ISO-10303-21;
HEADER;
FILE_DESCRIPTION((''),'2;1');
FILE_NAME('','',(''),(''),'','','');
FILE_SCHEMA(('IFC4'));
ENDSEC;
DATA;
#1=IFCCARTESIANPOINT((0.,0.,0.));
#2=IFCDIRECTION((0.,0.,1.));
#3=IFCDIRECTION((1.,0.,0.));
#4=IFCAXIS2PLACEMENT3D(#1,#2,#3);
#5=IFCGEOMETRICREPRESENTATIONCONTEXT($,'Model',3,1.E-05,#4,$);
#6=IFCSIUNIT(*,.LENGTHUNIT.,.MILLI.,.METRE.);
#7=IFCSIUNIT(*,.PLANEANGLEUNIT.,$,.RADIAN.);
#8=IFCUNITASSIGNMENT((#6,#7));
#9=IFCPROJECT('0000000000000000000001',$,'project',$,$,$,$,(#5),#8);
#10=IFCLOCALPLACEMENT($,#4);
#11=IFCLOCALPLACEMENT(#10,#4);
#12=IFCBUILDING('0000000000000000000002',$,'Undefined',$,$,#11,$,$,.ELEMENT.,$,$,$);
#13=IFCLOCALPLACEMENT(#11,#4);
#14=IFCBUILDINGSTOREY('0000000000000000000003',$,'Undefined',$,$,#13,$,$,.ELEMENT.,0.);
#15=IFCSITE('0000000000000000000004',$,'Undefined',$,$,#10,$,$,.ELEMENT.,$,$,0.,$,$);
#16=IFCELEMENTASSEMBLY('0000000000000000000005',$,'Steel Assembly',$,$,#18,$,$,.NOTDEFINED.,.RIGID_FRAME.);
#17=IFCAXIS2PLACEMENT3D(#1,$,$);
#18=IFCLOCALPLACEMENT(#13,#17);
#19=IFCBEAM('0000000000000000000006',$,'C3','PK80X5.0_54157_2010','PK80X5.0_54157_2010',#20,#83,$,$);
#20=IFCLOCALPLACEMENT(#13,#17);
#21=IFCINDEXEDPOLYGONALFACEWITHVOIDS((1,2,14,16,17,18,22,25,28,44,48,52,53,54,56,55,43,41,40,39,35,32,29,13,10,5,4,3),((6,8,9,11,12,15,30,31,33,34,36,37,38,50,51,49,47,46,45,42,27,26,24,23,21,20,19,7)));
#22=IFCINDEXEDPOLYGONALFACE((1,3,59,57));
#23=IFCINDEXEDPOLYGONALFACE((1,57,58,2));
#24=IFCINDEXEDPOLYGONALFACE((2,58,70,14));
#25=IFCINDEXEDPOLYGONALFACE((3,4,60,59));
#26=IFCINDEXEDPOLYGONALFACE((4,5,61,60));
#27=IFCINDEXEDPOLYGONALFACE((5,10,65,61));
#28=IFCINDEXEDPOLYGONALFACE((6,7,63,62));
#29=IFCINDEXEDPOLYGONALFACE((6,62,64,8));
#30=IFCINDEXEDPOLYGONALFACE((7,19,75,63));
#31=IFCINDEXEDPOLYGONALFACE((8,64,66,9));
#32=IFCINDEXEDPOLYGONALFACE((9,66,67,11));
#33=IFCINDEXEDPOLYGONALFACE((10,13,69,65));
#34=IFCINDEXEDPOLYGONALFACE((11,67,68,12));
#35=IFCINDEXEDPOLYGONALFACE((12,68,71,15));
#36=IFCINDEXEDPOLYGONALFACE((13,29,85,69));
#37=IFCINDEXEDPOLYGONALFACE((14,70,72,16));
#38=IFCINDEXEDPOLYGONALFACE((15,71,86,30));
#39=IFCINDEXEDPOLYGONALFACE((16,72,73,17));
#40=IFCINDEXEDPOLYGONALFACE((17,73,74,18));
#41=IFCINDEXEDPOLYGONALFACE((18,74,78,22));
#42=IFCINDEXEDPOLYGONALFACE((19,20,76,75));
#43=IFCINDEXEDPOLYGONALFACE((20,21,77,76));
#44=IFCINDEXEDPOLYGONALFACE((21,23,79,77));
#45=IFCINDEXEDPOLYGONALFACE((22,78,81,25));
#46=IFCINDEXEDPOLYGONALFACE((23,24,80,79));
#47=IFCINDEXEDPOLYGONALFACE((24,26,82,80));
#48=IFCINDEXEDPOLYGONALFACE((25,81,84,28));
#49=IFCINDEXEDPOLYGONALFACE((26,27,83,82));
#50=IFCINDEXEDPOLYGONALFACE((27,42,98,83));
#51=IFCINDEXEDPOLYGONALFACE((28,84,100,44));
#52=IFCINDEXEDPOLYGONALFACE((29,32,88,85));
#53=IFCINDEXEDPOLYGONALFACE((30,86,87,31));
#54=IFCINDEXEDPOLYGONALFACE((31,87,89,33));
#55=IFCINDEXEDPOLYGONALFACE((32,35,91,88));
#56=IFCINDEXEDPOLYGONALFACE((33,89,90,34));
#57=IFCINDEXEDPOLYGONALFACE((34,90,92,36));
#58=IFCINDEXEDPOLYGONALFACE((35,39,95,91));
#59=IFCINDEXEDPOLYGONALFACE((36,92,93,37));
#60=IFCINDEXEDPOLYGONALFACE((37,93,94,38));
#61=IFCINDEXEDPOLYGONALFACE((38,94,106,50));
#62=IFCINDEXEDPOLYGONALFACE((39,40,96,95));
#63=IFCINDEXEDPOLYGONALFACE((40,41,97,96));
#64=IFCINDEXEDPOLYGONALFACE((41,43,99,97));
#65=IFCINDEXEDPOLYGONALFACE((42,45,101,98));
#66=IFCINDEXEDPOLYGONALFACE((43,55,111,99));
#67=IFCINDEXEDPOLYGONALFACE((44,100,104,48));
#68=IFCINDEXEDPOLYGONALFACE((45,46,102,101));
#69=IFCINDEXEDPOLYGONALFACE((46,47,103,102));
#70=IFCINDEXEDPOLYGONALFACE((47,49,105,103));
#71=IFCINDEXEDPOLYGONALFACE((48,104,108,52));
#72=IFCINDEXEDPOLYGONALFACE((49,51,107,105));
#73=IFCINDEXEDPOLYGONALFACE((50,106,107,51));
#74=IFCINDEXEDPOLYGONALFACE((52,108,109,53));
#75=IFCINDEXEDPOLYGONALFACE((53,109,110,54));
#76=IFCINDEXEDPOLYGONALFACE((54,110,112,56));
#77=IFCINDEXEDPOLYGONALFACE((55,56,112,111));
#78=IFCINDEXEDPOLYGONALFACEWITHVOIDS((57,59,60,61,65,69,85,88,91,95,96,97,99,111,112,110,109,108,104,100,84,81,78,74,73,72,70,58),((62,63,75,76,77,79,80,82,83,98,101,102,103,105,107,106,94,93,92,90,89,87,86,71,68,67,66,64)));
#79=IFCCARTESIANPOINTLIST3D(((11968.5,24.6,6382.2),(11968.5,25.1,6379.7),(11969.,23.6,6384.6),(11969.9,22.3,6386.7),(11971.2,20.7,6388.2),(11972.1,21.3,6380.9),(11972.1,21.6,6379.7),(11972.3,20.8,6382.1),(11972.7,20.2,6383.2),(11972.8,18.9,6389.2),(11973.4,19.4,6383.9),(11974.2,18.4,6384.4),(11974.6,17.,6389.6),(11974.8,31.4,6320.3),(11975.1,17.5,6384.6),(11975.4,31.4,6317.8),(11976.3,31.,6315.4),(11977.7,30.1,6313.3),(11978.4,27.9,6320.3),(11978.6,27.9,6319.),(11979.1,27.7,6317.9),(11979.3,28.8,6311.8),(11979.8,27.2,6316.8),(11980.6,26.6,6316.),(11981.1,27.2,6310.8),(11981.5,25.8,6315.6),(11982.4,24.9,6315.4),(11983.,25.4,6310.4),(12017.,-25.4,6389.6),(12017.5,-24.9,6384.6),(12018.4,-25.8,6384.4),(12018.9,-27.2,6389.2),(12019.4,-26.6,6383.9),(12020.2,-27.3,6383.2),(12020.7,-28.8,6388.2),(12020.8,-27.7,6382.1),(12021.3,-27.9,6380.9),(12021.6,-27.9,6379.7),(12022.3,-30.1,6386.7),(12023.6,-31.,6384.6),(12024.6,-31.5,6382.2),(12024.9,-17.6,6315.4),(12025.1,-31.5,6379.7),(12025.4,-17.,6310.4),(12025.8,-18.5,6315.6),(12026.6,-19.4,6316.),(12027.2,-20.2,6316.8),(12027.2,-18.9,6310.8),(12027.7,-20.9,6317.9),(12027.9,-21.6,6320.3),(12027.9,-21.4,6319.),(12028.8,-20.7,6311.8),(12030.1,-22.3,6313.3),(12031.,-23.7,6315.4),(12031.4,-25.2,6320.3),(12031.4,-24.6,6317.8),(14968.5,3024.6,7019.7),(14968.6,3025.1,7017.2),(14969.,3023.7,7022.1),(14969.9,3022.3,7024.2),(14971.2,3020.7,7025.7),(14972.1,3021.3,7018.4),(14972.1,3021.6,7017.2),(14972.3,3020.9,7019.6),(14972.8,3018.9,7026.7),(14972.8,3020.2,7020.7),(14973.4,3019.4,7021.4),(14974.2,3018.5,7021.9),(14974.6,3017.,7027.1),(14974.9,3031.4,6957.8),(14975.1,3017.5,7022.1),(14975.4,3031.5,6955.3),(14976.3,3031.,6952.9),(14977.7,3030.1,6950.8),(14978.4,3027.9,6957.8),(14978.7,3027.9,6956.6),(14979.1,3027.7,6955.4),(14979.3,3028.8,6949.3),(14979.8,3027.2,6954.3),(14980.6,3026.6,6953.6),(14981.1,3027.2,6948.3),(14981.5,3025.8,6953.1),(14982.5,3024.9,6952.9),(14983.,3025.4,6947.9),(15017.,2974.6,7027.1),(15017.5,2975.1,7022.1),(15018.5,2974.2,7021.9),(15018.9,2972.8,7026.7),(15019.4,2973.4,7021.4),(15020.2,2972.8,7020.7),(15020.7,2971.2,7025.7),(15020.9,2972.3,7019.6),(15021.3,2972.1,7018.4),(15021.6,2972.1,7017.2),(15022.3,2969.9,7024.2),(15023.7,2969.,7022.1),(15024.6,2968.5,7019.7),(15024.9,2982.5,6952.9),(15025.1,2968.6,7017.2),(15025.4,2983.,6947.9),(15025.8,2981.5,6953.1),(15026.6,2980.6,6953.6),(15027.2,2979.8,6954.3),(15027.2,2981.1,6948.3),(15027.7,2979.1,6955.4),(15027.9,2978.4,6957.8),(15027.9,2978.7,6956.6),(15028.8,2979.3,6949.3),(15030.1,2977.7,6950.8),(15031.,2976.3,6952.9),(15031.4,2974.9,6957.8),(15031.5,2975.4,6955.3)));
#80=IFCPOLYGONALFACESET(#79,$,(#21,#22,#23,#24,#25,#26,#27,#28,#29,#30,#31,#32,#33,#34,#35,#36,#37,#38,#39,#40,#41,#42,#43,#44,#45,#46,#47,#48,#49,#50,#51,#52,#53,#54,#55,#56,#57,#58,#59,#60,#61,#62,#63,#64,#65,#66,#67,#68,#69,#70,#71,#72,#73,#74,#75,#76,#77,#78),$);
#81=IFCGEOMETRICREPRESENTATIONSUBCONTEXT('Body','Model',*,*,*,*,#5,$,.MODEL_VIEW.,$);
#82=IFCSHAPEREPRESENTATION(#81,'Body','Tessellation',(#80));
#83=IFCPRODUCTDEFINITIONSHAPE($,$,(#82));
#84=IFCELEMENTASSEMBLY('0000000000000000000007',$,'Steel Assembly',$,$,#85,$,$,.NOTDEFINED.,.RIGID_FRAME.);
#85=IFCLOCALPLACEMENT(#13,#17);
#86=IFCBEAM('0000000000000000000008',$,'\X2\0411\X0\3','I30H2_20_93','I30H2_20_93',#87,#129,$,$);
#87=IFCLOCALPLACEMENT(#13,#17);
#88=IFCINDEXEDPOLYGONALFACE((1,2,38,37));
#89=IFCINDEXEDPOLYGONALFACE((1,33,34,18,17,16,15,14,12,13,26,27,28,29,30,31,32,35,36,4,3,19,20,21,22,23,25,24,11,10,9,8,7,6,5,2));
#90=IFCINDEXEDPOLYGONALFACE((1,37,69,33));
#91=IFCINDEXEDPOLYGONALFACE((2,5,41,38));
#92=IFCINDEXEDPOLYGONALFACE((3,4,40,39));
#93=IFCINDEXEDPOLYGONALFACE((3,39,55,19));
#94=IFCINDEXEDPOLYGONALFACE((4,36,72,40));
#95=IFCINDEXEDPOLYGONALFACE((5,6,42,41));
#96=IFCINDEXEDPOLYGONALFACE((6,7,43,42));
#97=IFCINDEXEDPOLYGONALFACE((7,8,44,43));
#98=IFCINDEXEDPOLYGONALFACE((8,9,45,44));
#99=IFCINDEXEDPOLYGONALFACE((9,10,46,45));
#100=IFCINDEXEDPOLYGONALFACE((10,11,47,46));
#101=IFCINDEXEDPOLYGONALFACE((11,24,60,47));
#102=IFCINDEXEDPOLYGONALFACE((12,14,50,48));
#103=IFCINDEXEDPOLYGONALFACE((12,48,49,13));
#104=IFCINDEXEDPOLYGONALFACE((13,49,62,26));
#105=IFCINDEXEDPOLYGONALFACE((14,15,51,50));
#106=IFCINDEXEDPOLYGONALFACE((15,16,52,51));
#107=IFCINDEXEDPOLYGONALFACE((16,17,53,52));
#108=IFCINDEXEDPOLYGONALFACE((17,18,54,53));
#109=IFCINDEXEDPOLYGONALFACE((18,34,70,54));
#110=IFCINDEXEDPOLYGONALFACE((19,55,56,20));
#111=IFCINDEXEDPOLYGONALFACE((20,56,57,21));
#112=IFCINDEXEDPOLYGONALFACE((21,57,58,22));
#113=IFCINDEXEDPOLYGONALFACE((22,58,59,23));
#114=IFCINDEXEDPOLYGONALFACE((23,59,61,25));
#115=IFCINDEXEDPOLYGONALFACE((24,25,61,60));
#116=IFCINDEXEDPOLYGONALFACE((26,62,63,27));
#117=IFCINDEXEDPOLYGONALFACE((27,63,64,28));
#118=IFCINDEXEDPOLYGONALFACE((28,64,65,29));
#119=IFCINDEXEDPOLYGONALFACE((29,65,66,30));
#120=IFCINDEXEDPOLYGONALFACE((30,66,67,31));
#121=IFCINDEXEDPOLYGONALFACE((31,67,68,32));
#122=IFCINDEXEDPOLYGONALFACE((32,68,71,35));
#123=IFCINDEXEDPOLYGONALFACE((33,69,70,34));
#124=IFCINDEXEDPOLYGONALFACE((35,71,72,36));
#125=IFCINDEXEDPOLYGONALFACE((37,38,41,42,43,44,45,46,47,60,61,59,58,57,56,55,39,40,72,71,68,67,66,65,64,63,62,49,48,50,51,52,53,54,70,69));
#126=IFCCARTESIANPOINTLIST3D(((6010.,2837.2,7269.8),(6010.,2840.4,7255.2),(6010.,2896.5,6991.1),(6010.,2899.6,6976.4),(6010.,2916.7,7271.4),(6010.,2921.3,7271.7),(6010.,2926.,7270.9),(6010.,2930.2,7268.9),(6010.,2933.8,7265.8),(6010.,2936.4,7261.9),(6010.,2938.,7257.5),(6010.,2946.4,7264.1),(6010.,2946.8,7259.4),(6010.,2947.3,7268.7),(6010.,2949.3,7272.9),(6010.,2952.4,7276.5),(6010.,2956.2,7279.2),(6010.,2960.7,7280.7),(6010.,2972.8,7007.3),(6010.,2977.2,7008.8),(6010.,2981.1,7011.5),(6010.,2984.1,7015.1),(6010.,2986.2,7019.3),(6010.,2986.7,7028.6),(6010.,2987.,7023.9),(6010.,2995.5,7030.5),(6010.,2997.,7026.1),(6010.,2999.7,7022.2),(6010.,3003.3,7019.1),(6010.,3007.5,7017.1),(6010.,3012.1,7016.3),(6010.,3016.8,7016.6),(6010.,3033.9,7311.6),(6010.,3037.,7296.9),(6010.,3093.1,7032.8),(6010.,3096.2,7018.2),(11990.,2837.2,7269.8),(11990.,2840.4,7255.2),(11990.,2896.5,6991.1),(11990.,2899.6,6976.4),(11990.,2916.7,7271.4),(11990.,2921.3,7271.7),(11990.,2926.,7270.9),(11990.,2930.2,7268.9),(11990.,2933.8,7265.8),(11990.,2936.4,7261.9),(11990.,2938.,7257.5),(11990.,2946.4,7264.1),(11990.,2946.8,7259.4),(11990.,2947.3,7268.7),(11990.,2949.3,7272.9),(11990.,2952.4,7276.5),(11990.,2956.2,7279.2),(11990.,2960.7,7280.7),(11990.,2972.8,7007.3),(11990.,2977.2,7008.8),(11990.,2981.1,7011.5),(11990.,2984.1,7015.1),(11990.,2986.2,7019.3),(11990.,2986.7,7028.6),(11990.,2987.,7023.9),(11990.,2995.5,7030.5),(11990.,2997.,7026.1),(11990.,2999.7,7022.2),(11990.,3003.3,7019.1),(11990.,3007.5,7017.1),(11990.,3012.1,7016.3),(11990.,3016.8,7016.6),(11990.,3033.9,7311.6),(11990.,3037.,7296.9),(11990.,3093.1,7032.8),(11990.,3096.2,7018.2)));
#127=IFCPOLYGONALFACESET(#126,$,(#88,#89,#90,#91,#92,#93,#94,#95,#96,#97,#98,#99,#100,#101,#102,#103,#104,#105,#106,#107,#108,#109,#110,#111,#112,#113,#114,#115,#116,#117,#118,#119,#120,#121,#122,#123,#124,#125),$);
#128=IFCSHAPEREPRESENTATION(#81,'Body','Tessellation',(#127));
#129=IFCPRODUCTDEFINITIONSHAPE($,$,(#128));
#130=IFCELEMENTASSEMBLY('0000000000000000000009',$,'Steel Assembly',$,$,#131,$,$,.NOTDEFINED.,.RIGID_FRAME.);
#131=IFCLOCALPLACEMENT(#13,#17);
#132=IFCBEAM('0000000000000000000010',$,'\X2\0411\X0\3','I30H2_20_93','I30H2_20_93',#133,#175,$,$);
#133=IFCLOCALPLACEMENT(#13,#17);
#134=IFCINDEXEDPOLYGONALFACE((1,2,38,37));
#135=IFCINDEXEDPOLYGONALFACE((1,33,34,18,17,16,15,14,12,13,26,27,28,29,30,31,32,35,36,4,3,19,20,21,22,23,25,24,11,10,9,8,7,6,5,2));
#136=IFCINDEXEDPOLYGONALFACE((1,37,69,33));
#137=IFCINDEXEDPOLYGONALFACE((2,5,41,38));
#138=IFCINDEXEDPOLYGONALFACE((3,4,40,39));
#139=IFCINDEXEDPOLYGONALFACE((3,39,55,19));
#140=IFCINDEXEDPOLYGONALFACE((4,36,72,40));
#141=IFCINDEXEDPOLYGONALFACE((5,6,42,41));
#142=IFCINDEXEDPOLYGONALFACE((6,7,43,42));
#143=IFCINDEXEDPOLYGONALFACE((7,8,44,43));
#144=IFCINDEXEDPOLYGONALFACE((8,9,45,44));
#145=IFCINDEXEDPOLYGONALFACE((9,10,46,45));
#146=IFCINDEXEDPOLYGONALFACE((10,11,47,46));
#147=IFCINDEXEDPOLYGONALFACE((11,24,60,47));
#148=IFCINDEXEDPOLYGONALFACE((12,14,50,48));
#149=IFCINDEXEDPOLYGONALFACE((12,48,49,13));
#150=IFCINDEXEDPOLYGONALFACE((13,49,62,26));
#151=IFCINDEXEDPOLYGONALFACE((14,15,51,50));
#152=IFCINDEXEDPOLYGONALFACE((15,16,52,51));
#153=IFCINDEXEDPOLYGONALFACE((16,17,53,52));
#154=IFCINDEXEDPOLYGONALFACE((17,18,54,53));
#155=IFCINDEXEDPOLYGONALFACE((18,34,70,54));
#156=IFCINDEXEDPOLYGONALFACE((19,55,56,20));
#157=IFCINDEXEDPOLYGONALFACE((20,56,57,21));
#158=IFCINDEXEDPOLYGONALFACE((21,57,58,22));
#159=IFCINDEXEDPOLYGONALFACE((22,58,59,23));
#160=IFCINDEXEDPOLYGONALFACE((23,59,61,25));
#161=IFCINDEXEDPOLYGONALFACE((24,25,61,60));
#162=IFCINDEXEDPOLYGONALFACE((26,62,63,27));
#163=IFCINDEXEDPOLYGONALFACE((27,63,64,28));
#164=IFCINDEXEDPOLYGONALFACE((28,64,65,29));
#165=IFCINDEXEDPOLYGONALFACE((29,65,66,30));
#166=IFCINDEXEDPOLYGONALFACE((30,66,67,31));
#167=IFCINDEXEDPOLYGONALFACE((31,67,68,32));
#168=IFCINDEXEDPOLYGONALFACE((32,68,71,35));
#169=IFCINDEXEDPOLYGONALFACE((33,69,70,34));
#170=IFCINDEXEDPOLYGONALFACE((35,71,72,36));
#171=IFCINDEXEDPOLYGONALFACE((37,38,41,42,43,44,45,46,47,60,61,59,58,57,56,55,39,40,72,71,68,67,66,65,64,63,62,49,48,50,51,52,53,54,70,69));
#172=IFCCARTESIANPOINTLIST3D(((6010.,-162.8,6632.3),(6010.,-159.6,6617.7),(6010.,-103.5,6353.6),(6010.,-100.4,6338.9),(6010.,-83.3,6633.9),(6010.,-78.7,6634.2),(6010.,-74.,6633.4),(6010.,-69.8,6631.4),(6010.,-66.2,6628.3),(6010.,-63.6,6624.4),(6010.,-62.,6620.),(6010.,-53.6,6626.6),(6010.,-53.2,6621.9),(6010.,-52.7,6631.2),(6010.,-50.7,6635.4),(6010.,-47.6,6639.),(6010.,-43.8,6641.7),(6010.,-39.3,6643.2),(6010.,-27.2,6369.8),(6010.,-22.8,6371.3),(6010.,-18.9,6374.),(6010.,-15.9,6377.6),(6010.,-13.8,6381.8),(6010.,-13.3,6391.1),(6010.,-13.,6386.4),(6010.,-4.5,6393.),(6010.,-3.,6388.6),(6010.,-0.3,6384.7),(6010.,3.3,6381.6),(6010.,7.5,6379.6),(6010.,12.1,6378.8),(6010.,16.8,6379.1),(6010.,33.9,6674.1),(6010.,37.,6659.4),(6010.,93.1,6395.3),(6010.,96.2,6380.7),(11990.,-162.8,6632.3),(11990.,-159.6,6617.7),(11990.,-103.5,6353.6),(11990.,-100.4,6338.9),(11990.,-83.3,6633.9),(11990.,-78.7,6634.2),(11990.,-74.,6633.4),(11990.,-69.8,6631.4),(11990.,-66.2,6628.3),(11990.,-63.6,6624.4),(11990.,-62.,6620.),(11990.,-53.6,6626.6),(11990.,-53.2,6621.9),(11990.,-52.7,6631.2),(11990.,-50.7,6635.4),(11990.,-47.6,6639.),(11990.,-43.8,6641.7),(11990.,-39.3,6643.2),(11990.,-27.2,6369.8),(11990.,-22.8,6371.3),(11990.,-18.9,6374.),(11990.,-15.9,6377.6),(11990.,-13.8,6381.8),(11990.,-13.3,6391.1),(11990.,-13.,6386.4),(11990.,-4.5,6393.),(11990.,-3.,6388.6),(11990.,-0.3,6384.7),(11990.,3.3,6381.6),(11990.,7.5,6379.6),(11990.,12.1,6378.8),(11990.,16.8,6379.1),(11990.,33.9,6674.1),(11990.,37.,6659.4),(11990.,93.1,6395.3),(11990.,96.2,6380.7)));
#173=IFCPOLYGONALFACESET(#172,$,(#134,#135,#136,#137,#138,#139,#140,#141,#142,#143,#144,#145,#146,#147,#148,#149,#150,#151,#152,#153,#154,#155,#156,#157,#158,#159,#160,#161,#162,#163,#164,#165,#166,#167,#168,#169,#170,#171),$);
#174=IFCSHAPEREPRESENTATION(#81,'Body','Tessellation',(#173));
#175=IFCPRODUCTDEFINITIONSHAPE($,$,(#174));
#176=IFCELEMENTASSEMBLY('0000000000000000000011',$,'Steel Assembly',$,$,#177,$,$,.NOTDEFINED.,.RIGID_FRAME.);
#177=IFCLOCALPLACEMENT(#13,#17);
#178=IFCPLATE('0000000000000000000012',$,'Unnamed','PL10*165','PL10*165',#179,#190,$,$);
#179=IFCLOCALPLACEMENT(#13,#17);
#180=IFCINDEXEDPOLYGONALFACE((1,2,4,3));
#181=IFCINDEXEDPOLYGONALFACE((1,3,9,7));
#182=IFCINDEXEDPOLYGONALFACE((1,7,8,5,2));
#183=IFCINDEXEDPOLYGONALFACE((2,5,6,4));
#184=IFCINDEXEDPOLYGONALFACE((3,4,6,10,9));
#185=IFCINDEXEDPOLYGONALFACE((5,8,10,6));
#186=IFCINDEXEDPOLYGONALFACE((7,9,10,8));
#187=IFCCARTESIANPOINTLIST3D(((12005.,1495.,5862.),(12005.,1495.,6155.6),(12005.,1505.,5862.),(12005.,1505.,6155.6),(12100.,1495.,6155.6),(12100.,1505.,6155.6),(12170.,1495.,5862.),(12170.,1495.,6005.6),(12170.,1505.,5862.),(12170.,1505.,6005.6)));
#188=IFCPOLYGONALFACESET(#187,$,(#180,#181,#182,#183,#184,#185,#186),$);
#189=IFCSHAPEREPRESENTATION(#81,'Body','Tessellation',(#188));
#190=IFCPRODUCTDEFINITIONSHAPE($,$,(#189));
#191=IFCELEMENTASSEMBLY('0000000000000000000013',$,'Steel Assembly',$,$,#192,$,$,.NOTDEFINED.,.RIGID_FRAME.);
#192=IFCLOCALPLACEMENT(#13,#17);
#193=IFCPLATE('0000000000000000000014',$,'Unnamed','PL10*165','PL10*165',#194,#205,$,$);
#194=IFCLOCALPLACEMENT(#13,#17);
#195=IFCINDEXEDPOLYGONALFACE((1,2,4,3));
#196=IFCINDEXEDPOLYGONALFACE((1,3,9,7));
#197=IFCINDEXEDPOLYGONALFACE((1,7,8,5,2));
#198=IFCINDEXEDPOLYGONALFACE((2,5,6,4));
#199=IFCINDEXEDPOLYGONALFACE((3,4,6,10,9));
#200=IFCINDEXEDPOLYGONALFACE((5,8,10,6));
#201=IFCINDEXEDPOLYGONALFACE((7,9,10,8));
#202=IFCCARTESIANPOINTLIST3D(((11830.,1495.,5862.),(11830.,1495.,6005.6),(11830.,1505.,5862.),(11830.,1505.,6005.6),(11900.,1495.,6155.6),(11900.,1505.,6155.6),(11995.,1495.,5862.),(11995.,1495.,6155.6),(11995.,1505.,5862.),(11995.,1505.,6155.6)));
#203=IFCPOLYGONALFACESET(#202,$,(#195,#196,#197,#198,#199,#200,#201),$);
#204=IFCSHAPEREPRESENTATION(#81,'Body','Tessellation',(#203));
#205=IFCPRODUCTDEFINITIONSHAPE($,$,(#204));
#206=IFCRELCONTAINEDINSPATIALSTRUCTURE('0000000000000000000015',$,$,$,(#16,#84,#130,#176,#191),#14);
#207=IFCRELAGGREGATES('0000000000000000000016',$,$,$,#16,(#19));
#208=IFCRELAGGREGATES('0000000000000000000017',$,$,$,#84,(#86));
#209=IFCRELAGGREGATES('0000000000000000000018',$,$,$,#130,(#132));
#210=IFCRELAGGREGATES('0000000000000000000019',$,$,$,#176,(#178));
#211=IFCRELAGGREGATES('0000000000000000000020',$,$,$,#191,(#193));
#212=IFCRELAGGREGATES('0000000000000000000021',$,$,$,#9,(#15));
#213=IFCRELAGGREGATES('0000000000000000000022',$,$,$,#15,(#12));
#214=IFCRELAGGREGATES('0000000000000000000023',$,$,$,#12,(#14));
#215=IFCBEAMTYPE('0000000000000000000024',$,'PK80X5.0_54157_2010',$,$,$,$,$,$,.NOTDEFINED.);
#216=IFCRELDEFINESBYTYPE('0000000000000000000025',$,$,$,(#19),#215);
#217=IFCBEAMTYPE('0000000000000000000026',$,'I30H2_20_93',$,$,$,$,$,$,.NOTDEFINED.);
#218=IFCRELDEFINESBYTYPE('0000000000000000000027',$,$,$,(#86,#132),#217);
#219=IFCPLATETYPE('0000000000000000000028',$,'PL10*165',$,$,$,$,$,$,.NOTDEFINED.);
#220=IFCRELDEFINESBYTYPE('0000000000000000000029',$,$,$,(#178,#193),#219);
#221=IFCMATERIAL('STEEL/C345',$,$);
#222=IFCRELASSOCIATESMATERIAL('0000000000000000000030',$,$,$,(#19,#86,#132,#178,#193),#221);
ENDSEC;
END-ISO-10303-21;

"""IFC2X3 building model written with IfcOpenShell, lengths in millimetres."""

from ifc_helpers import new_model, si_unit, frame, origin_with_axes, origin_2d_with_axis, place, context, subcontext, project, spatial, polyline, hollow_rectangle, i_section, outline, extrude, material, type_object, element, aggregate, save


model = new_model("IFC2X3")

# Units and contexts
model_context = context("Model", 3, precision=1e-05, world=origin_with_axes())
body_context = subcontext(model_context, "Body", "Model", "MODEL_VIEW")
ifc_project = project(units=[si_unit("LENGTHUNIT", "METRE", prefix="MILLI"), si_unit("PLANEANGLEUNIT", "RADIAN")], contexts=[model_context])

# Site, building, storey
site_placement = place(None, origin_with_axes())
site = spatial("IfcSite", under=ifc_project, at=site_placement, Name="Undefined", CompositionType="ELEMENT", RefElevation=0.0)
building_placement = place(site_placement, origin_with_axes())
building = spatial("IfcBuilding", under=site, at=building_placement, Name="Undefined", CompositionType="ELEMENT")
storey_placement = place(building_placement, origin_with_axes())
storey = spatial("IfcBuildingStorey", under=building, at=storey_placement, Name="Undefined", CompositionType="ELEMENT", Elevation=0.0)

# Element assemblies, beams
ifc_material = material(Name="STEEL/C345")
beam_type_1 = type_object("IfcBeamType", Name="PK80X5.0_54157_2010", PredefinedType="NOTDEFINED")
assembly_1_placement = place(storey_placement, origin_with_axes())
assembly_1 = element("IfcElementAssembly", 1, at=assembly_1_placement, inside=storey, Name="Steel Assembly", AssemblyPlace="NOTDEFINED", PredefinedType="RIGID_FRAME")
beam_1_placement = place(assembly_1_placement, frame((12000.0, 0.0, 6350.0), z_axis=(-0.10507, -0.10507, 0.988899), x_axis=(0.699257, 0.699257, 0.148592)))
beam_1 = element("IfcBeam", 2, at=beam_1_placement, type_object=beam_type_1, material=ifc_material, Name="C3", Description="PK80X5.0_54157_2010", ObjectType="PK80X5.0_54157_2010", context=body_context, shape_type="SweptSolid", body=[
    extrude(hollow_rectangle(XDim=80.0, YDim=80.0, WallThickness=5.0, InnerFilletRadius=5.0, OuterFilletRadius=10.0, at=origin_2d_with_axis()), frame((4290.3, 0.0, 0.0), z_axis=(-1.0, 0.0, 0.0), x_axis=(0.0, -1.0, 0.0)), (0.0, 0.0, 1.0), 4290.3),
])
aggregate(assembly_1, [beam_1])
assembly_2_placement = place(storey_placement, origin_with_axes())
assembly_2 = element("IfcElementAssembly", 3, at=assembly_2_placement, inside=storey, Name="Steel Assembly", AssemblyPlace="NOTDEFINED", PredefinedType="RIGID_FRAME")
beam_type_2 = type_object("IfcBeamType", Name="I30H2_20_93", PredefinedType="NOTDEFINED")
beam_2_placement = place(assembly_2_placement, frame((11990.0, 2966.7, 7144.0), z_axis=(0.0, 0.207912, -0.978148), x_axis=(-1.0, 0.0, 0.0)))
beam_2 = element("IfcBeam", 4, at=beam_2_placement, type_object=beam_type_2, material=ifc_material, Name="Б3", Description="I30H2_20_93", ObjectType="I30H2_20_93", context=body_context, shape_type="SweptSolid", body=[
    extrude(i_section(OverallWidth=201.0, OverallDepth=300.0, WebThickness=9.0, FlangeThickness=15.0, FilletRadius=18.0, at=origin_2d_with_axis()), frame((5980.0, 0.0, 0.0), z_axis=(-1.0, 0.0, 0.0), x_axis=(0.0, -1.0, 0.0)), (0.0, 0.0, 1.0), 5980.0),
])
aggregate(assembly_2, [beam_2])
assembly_3_placement = place(storey_placement, origin_with_axes())
assembly_3 = element("IfcElementAssembly", 5, at=assembly_3_placement, inside=storey, Name="Steel Assembly", AssemblyPlace="NOTDEFINED", PredefinedType="RIGID_FRAME")
beam_3_placement = place(assembly_3_placement, frame((11990.0, -33.3, 6506.5), z_axis=(0.0, 0.207912, -0.978148), x_axis=(-1.0, 0.0, 0.0)))
beam_3 = element("IfcBeam", 6, at=beam_3_placement, type_object=beam_type_2, material=ifc_material, Name="Б3", Description="I30H2_20_93", ObjectType="I30H2_20_93", context=body_context, shape_type="SweptSolid", body=[
    extrude(i_section(OverallWidth=201.0, OverallDepth=300.0, WebThickness=9.0, FlangeThickness=15.0, FilletRadius=18.0, at=origin_2d_with_axis()), frame((5980.0, 0.0, 0.0), z_axis=(-1.0, 0.0, 0.0), x_axis=(0.0, -1.0, 0.0)), (0.0, 0.0, 1.0), 5980.0),
])
aggregate(assembly_3, [beam_3])

# Element assemblies, plates
assembly_4_placement = place(storey_placement, origin_with_axes())
assembly_4 = element("IfcElementAssembly", 7, at=assembly_4_placement, inside=storey, Name="Steel Assembly", AssemblyPlace="NOTDEFINED", PredefinedType="RIGID_FRAME")
plate_type_1 = type_object("IfcPlateType", Name="PL10*165", PredefinedType="NOTDEFINED")
plate_1_placement = place(assembly_4_placement, frame((12005.0, 1500.0, 5862.0), z_axis=(0.0, -1.0, 0.0), x_axis=(1.0, 0.0, 0.0)))
plate_1 = element("IfcPlate", 8, at=plate_1_placement, type_object=plate_type_1, material=ifc_material, Name="Unnamed", Description="PL10*165", ObjectType="PL10*165", context=body_context, shape_type="SweptSolid", body=[
    extrude(outline(polyline([(0.0, 0.0), (165.0, 0.0), (165.0, 143.6), (95.0, 293.6), (0.0, 293.6), (0.0, 0.0)])), frame((0.0, 0.0, -5.0), z_axis=(0.0, 0.0, 1.0), x_axis=(1.0, 0.0, 0.0)), (0.0, 0.0, 1.0), 10.0),
])
aggregate(assembly_4, [plate_1])
assembly_5_placement = place(storey_placement, origin_with_axes())
assembly_5 = element("IfcElementAssembly", 9, at=assembly_5_placement, inside=storey, Name="Steel Assembly", AssemblyPlace="NOTDEFINED", PredefinedType="RIGID_FRAME")
plate_2_placement = place(assembly_5_placement, frame((11995.0, 1500.0, 5862.0), z_axis=(0.0, 1.0, 0.0), x_axis=(-1.0, 0.0, 0.0)))
plate_2 = element("IfcPlate", 10, at=plate_2_placement, type_object=plate_type_1, material=ifc_material, Name="Unnamed", Description="PL10*165", ObjectType="PL10*165", context=body_context, shape_type="SweptSolid", body=[
    extrude(outline(polyline([(0.0, 0.0), (165.0, 0.0), (165.0, 143.6), (95.0, 293.6), (0.0, 293.6), (0.0, 0.0)])), frame((0.0, 0.0, -5.0), z_axis=(0.0, 0.0, 1.0), x_axis=(1.0, 0.0, 0.0)), (0.0, 0.0, 1.0), 10.0),
])
aggregate(assembly_5, [plate_2])

save(model, "model.ifc")
